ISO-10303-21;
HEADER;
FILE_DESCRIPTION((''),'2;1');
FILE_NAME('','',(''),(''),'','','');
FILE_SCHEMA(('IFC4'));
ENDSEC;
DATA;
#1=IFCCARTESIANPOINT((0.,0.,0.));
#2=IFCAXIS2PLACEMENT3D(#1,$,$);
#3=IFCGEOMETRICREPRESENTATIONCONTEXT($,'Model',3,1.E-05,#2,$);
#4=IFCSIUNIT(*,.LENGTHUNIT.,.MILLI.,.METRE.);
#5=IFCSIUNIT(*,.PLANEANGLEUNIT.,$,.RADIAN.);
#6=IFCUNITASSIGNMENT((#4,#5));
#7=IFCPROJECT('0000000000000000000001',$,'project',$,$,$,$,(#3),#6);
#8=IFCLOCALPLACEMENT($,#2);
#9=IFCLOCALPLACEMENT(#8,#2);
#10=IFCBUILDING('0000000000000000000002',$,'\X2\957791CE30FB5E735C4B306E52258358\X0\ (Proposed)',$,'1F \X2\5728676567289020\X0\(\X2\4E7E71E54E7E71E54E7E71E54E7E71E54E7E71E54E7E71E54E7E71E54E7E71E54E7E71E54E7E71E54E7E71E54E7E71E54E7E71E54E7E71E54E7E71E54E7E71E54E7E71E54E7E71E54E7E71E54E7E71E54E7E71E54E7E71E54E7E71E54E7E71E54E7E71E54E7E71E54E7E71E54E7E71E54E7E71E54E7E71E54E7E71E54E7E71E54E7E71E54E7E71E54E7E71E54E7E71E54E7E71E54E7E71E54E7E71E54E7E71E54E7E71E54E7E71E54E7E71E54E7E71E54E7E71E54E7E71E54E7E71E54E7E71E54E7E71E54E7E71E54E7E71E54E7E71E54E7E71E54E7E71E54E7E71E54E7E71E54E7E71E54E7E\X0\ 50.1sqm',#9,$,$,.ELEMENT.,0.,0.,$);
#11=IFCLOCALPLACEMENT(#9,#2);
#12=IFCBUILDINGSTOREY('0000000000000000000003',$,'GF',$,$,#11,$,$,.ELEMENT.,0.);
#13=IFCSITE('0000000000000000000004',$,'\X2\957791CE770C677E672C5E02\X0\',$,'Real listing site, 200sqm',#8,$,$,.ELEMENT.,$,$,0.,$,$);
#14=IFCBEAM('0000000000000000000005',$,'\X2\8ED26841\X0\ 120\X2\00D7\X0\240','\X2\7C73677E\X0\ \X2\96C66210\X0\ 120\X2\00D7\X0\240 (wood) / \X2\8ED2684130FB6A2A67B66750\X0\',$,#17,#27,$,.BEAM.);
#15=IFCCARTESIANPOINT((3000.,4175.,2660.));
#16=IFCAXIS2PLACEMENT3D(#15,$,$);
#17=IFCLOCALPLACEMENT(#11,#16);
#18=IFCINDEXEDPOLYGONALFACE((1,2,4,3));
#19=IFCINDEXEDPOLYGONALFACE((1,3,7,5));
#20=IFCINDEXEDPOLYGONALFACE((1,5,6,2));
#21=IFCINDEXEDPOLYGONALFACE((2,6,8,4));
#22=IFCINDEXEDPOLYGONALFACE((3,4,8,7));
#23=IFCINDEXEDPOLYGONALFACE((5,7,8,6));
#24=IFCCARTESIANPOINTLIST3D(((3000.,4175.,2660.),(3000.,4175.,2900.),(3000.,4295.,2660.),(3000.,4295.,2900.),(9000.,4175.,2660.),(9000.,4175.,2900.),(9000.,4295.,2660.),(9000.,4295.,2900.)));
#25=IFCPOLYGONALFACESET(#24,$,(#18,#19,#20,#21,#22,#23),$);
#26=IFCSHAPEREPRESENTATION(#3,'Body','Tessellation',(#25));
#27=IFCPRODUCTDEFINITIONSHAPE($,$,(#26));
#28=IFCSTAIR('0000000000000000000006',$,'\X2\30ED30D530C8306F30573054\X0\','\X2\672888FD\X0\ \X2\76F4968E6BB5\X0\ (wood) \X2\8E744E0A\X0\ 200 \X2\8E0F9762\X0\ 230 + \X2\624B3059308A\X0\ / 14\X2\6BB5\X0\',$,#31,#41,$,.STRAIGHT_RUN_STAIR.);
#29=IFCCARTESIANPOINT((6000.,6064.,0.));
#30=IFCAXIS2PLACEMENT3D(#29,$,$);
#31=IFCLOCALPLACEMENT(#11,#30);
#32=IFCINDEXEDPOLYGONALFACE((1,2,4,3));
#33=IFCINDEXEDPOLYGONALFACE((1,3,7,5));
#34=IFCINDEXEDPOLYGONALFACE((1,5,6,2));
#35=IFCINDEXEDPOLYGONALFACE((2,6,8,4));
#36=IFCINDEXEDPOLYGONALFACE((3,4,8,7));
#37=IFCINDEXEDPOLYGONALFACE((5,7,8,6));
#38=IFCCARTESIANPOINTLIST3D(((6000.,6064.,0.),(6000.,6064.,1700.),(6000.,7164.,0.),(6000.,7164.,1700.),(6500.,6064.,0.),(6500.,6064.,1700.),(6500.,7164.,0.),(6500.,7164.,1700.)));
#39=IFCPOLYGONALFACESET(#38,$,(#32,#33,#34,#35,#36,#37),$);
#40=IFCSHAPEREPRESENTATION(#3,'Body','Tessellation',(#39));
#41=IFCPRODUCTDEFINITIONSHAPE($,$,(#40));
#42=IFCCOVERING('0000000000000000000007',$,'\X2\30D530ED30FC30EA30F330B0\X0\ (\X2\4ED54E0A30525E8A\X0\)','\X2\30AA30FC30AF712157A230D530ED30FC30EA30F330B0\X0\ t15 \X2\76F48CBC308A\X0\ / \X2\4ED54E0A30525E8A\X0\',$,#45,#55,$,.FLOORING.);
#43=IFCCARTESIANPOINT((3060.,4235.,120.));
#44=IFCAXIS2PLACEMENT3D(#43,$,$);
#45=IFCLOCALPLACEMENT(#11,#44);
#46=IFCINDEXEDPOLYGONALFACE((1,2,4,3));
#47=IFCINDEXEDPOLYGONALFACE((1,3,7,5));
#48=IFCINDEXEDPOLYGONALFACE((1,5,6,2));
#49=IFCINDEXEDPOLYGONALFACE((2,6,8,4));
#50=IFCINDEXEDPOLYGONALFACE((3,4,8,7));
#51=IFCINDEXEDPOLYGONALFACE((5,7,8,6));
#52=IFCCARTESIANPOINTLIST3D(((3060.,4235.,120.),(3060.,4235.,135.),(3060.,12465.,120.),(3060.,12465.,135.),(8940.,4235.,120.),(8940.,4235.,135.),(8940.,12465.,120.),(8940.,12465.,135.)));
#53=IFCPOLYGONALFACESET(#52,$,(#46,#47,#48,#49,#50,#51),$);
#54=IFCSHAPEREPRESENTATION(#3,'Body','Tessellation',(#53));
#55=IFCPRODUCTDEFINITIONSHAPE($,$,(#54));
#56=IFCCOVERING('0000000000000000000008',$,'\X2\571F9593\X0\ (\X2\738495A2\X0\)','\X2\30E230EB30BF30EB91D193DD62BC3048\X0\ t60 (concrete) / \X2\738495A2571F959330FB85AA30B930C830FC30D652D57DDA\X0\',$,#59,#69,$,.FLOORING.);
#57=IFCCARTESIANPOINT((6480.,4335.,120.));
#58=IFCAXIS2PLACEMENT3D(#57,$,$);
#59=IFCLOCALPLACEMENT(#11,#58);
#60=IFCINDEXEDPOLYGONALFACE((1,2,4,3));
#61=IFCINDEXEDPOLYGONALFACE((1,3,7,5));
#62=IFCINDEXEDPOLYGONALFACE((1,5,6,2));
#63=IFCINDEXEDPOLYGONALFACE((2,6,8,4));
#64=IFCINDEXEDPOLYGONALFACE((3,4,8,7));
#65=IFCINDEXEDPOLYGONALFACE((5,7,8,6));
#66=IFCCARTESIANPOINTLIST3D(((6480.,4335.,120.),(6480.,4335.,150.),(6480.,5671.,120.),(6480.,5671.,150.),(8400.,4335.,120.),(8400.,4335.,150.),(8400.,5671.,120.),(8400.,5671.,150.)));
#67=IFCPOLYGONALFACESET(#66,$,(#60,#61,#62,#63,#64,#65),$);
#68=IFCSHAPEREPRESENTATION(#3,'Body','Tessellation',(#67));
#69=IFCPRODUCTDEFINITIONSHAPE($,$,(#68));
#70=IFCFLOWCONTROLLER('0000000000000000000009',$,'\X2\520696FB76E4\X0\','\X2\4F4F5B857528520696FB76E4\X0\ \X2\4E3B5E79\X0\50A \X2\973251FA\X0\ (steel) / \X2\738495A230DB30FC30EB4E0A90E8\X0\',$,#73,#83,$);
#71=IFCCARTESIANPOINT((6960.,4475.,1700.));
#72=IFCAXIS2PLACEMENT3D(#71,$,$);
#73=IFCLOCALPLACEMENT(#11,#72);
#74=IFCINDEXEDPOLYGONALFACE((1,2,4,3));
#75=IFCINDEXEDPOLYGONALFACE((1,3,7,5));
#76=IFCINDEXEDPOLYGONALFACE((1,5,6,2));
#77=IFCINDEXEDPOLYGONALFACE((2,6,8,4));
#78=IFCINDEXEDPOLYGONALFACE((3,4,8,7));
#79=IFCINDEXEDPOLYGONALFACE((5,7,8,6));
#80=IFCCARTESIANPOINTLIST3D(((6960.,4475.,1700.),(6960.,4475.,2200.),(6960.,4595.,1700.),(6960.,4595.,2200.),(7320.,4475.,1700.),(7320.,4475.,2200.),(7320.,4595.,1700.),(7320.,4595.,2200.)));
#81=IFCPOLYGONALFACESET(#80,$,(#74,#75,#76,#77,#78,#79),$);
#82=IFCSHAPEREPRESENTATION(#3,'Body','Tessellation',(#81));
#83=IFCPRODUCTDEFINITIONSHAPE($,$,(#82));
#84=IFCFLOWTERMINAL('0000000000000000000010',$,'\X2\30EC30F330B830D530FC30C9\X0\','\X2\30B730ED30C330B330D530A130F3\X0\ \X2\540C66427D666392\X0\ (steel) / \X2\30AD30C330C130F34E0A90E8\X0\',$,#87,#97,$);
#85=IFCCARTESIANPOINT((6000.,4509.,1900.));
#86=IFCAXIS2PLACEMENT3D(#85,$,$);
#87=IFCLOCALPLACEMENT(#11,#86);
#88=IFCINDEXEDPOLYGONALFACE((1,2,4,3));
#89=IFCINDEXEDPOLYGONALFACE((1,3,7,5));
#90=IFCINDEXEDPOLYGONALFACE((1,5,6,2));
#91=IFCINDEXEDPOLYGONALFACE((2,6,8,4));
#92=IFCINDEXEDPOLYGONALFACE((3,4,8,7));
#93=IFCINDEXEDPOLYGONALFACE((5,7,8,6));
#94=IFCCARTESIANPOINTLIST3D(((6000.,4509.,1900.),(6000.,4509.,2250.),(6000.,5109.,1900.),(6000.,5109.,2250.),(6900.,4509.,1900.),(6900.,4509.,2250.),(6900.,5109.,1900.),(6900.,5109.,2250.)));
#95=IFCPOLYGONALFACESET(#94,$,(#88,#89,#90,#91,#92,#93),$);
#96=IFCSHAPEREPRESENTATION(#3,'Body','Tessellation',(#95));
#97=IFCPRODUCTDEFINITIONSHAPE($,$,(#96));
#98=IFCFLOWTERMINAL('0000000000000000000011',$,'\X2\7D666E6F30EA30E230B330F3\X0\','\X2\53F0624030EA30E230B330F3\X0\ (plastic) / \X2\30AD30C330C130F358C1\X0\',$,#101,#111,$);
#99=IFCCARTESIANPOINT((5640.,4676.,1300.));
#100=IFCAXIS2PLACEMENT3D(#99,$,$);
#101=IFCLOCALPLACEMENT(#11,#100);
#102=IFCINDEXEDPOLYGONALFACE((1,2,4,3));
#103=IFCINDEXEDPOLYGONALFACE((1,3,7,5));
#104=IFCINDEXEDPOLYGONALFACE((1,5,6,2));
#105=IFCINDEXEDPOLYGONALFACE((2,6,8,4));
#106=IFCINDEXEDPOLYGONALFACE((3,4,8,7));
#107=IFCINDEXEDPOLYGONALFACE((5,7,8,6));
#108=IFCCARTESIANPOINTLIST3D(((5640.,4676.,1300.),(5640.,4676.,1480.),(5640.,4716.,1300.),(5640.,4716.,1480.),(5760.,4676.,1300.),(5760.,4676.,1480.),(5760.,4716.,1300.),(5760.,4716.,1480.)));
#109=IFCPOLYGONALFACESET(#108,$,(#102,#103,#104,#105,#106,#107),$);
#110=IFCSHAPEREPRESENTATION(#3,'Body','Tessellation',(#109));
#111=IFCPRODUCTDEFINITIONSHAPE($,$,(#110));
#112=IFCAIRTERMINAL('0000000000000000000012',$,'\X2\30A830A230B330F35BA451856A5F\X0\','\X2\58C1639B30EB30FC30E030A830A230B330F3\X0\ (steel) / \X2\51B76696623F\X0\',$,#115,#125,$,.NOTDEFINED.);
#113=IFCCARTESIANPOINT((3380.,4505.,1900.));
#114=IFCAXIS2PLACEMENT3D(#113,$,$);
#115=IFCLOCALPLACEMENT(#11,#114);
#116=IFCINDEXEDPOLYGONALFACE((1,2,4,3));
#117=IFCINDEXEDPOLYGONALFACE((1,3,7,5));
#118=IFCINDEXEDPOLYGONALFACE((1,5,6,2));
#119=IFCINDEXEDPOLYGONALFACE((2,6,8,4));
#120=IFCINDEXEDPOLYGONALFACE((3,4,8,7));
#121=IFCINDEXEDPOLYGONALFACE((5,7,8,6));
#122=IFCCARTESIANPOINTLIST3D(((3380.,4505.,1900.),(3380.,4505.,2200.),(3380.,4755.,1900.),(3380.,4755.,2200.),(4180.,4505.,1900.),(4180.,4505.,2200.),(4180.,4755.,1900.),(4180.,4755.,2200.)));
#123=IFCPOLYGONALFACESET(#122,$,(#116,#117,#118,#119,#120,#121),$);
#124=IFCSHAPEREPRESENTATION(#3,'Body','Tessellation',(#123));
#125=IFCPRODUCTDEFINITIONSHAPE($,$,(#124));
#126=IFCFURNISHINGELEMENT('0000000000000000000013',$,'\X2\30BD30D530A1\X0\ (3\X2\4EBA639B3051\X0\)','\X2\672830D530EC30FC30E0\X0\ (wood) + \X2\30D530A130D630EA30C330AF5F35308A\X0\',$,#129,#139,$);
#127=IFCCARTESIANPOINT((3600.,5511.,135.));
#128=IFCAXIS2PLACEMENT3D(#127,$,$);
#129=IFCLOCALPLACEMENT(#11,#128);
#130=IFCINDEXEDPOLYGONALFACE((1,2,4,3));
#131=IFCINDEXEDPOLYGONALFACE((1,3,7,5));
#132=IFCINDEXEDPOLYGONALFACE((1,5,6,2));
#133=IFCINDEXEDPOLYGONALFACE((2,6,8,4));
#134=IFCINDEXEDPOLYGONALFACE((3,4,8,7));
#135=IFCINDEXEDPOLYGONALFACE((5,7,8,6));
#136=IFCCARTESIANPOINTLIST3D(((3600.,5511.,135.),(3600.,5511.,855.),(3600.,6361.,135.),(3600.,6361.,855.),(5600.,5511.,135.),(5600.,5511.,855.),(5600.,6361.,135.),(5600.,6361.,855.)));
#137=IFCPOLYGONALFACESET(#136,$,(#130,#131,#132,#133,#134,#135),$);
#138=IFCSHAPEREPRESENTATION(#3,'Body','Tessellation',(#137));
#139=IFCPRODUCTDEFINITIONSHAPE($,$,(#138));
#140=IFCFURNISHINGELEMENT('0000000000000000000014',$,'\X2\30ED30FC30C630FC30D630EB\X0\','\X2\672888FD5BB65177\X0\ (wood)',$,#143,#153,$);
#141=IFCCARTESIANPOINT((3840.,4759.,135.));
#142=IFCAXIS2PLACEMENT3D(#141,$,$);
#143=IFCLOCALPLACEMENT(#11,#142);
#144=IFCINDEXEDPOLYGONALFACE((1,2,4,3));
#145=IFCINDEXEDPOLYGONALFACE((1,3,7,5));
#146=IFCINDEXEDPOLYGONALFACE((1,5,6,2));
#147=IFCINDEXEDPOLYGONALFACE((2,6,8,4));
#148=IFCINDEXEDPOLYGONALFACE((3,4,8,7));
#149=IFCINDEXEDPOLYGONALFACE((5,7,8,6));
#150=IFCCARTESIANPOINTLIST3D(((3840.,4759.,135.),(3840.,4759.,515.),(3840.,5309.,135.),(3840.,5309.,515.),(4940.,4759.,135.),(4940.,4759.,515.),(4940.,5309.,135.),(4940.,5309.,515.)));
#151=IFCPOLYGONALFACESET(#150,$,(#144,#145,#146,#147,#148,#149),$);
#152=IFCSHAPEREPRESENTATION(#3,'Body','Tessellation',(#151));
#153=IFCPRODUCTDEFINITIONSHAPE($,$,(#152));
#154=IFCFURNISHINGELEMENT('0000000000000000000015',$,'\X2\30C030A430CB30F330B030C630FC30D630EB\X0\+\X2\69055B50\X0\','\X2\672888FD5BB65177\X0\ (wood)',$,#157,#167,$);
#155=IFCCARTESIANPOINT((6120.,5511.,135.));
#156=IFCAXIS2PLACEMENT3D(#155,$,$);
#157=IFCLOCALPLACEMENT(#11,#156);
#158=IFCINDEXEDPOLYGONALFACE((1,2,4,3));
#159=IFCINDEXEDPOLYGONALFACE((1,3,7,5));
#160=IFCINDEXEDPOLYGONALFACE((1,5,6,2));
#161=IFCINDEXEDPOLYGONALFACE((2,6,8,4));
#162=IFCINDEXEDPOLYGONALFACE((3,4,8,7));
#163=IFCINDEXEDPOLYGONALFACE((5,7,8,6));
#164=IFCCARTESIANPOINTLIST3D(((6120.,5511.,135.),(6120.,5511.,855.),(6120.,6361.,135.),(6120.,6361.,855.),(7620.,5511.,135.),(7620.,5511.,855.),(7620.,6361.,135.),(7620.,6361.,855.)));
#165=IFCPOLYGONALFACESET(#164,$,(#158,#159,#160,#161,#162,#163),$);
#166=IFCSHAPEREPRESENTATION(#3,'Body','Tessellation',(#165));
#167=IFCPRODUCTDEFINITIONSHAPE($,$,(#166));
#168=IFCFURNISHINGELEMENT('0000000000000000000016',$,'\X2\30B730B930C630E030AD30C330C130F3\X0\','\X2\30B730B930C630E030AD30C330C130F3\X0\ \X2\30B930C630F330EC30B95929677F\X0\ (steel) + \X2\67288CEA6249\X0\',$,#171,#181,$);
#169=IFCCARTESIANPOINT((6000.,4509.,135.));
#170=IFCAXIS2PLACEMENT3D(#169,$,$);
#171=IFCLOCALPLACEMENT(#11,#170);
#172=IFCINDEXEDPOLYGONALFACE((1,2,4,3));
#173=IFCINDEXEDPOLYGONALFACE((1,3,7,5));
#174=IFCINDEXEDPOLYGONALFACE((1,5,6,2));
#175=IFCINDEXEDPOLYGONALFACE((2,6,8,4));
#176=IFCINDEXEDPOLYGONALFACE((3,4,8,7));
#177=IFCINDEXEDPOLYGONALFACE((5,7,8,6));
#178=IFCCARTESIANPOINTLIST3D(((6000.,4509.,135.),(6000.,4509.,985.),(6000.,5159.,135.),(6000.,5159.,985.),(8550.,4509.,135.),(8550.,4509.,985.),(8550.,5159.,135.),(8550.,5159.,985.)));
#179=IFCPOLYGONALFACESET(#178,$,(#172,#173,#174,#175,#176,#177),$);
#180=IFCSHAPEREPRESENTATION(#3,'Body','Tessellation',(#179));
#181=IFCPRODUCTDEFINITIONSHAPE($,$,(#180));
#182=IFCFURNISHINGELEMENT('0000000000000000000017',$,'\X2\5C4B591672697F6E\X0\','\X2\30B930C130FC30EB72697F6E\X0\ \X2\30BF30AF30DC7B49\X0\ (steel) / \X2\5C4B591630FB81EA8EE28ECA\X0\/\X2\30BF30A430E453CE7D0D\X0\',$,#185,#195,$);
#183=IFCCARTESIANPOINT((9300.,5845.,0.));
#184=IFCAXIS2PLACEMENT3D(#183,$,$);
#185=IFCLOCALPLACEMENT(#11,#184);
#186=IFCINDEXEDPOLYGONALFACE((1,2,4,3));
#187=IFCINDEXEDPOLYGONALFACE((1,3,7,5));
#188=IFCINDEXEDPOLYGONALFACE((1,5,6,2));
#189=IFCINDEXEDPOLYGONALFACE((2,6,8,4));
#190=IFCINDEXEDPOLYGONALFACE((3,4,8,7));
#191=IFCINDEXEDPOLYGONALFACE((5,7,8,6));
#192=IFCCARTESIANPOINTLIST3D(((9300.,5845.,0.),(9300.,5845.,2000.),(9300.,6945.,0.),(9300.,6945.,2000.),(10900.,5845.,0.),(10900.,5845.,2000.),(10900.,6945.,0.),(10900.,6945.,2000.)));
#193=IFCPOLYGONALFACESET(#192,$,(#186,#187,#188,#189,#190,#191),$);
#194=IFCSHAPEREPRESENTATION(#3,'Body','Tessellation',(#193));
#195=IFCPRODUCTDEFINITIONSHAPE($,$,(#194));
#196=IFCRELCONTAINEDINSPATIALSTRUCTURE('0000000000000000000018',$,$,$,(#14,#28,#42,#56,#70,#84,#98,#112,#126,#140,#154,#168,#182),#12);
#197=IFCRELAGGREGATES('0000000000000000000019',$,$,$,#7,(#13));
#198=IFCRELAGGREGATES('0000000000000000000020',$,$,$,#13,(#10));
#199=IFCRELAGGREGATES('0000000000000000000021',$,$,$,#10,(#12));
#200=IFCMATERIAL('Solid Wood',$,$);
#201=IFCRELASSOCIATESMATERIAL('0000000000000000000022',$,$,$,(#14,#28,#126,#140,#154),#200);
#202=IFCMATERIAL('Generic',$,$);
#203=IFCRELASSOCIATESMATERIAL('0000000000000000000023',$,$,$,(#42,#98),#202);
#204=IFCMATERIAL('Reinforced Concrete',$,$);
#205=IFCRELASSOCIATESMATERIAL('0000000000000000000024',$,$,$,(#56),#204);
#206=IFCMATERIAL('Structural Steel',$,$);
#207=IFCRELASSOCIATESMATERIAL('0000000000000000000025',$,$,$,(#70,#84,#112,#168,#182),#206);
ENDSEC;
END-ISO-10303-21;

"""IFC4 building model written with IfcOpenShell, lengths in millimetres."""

from ifc_helpers import new_model, si_unit, frame, frame_2d, origin, place, context, project, spatial, rectangle, extrude, material, element, save


model = new_model("IFC4")

# Units and contexts
model_context = context("Model", 3, precision=1e-05, world=origin())
ifc_project = project(units=[si_unit("LENGTHUNIT", "METRE", prefix="MILLI"), si_unit("PLANEANGLEUNIT", "RADIAN")], contexts=[model_context])

# Site, building, storey
site_placement = place(None, origin())
site = spatial("IfcSite", under=ifc_project, at=site_placement, Name="長野県松本市", ObjectType="Real listing site, 200sqm", CompositionType="ELEMENT", RefElevation=0.0)
building_placement = place(site_placement, origin())
building = spatial("IfcBuilding", under=site, at=building_placement, Name="長野・平屋の別荘 (Proposed)", ObjectType="1F 在来木造(乾燥乾燥乾燥乾燥乾燥乾燥乾燥乾燥乾燥乾燥乾燥乾燥乾燥乾燥乾燥乾燥乾燥乾燥乾燥乾燥乾燥乾燥乾燥乾燥乾燥乾燥乾燥乾燥乾燥乾燥乾燥乾燥乾燥乾燥乾燥乾燥乾燥乾燥乾燥乾燥乾燥乾燥乾燥乾燥乾燥乾燥乾燥乾燥乾燥乾燥乾燥乾燥乾燥乾燥乾燥乾燥乾燥乾 50.1sqm", CompositionType="ELEMENT", ElevationOfRefHeight=0.0, ElevationOfTerrain=0.0)
storey_placement = place(building_placement, origin())
storey = spatial("IfcBuildingStorey", under=building, at=storey_placement, Name="GF", CompositionType="ELEMENT", Elevation=0.0)

# Beam
ifc_material_1 = material(Name="Solid Wood")
beam_1_placement = place(storey_placement, frame((3000.0, 4175.0, 2660.0)))
element("IfcBeam", 1, at=beam_1_placement, inside=storey, material=ifc_material_1, Name="軒桁 120×240", Description="米松 集成 120×240 (wood) / 軒桁・横架材", PredefinedType="BEAM", context=model_context, shape_type="SweptSolid", body=[
    extrude(rectangle(XDim=6000.0, YDim=120.0, at=frame_2d((3000.0, 60.0))), frame((3000.0, 4175.0, 2660.0)), (0.0, 0.0, 1.0), 240.0),
])

# Stair
stair_placement = place(storey_placement, frame((6000.0, 6064.0, 0.0)))
element("IfcStair", 2, at=stair_placement, inside=storey, material=ifc_material_1, Name="ロフトはしご", Description="木製 直階段 (wood) 蹴上 200 踏面 230 + 手すり / 14段", PredefinedType="STRAIGHT_RUN_STAIR", context=model_context, shape_type="SweptSolid", body=[
    extrude(rectangle(XDim=500.0, YDim=1100.0, at=frame_2d((250.0, 550.0))), frame((6000.0, 6064.0, 0.0)), (0.0, 0.0, 1.0), 1700.0),
])

# Coverings
ifc_material_2 = material(Name="Generic")
covering_1_placement = place(storey_placement, frame((3060.0, 4235.0, 120.0)))
element("IfcCovering", 3, at=covering_1_placement, inside=storey, material=ifc_material_2, Name="フローリング (仕上げ床)", Description="オーク無垢フローリング t15 直貼り / 仕上げ床", PredefinedType="FLOORING", context=model_context, shape_type="SweptSolid", body=[
    extrude(rectangle(XDim=5880.0, YDim=8230.0, at=frame_2d((2940.0, 4115.0))), frame((3060.0, 4235.0, 120.0)), (0.0, 0.0, 1.0), 15.0),
])
ifc_material_3 = material(Name="Reinforced Concrete")
covering_2_placement = place(storey_placement, frame((6480.0, 4335.0, 120.0)))
element("IfcCovering", 4, at=covering_2_placement, inside=storey, material=ifc_material_3, Name="土間 (玄関)", Description="モルタル金鏝押え t60 (concrete) / 玄関土間・薪ストーブ動線", PredefinedType="FLOORING", context=model_context, shape_type="SweptSolid", body=[
    extrude(rectangle(XDim=1920.0, YDim=1336.0, at=frame_2d((960.0, 668.0))), frame((6480.0, 4335.0, 120.0)), (0.0, 0.0, 1.0), 30.0),
])

# Flow controller
ifc_material_4 = material(Name="Structural Steel")
flow_controller_placement = place(storey_placement, frame((6960.0, 4475.0, 1700.0)))
element("IfcFlowController", 5, at=flow_controller_placement, inside=storey, material=ifc_material_4, Name="分電盤", Description="住宅用分電盤 主幹50A 露出 (steel) / 玄関ホール上部", context=model_context, shape_type="SweptSolid", body=[
    extrude(rectangle(XDim=360.0, YDim=120.0, at=frame_2d((180.0, 60.0))), frame((6960.0, 4475.0, 1700.0)), (0.0, 0.0, 1.0), 500.0),
])

# Flow terminals
flow_terminal_1_placement = place(storey_placement, frame((6000.0, 4509.0, 1900.0)))
element("IfcFlowTerminal", 6, at=flow_terminal_1_placement, inside=storey, material=ifc_material_4, Name="レンジフード", Description="シロッコファン 同時給排 (steel) / キッチン上部", context=model_context, shape_type="SweptSolid", body=[
    extrude(rectangle(XDim=900.0, YDim=600.0, at=frame_2d((450.0, 300.0))), frame((6000.0, 4509.0, 1900.0)), (0.0, 0.0, 1.0), 350.0),
])
flow_terminal_2_placement = place(storey_placement, frame((5640.0, 4676.0, 1300.0)))
element("IfcFlowTerminal", 7, at=flow_terminal_2_placement, inside=storey, material=ifc_material_2, Name="給湯リモコン", Description="台所リモコン (plastic) / キッチン壁", context=model_context, shape_type="SweptSolid", body=[
    extrude(rectangle(XDim=120.0, YDim=40.0, at=frame_2d((60.0, 20.0))), frame((5640.0, 4676.0, 1300.0)), (0.0, 0.0, 1.0), 180.0),
])

# Air terminal
air_terminal_placement = place(storey_placement, frame((3380.0, 4505.0, 1900.0)))
element("IfcAirTerminal", 8, at=air_terminal_placement, inside=storey, material=ifc_material_4, Name="エアコン室内機", Description="壁掛ルームエアコン (steel) / 冷暖房", PredefinedType="NOTDEFINED", context=model_context, shape_type="SweptSolid", body=[
    extrude(rectangle(XDim=800.0, YDim=250.0, at=frame_2d((400.0, 125.0))), frame((3380.0, 4505.0, 1900.0)), (0.0, 0.0, 1.0), 300.0),
])

# Furnishing elements
furnishing_1_placement = place(storey_placement, frame((3600.0, 5511.0, 135.0)))
element("IfcFurnishingElement", 9, at=furnishing_1_placement, inside=storey, material=ifc_material_1, Name="ソファ (3人掛け)", Description="木フレーム (wood) + ファブリック張り", context=model_context, shape_type="SweptSolid", body=[
    extrude(rectangle(XDim=2000.0, YDim=850.0, at=frame_2d((1000.0, 425.0))), frame((3600.0, 5511.0, 135.0)), (0.0, 0.0, 1.0), 720.0),
])
furnishing_2_placement = place(storey_placement, frame((3840.0, 4759.0, 135.0)))
element("IfcFurnishingElement", 10, at=furnishing_2_placement, inside=storey, material=ifc_material_1, Name="ローテーブル", Description="木製家具 (wood)", context=model_context, shape_type="SweptSolid", body=[
    extrude(rectangle(XDim=1100.0, YDim=550.0, at=frame_2d((550.0, 275.0))), frame((3840.0, 4759.0, 135.0)), (0.0, 0.0, 1.0), 380.0),
])
furnishing_3_placement = place(storey_placement, frame((6120.0, 5511.0, 135.0)))
element("IfcFurnishingElement", 11, at=furnishing_3_placement, inside=storey, material=ifc_material_1, Name="ダイニングテーブル+椅子", Description="木製家具 (wood)", context=model_context, shape_type="SweptSolid", body=[
    extrude(rectangle(XDim=1500.0, YDim=850.0, at=frame_2d((750.0, 425.0))), frame((6120.0, 5511.0, 135.0)), (0.0, 0.0, 1.0), 720.0),
])
furnishing_4_placement = place(storey_placement, frame((6000.0, 4509.0, 135.0)))
element("IfcFurnishingElement", 12, at=furnishing_4_placement, inside=storey, material=ifc_material_4, Name="システムキッチン", Description="システムキッチン ステンレス天板 (steel) + 木質扉", context=model_context, shape_type="SweptSolid", body=[
    extrude(rectangle(XDim=2550.0, YDim=650.0, at=frame_2d((1275.0, 325.0))), frame((6000.0, 4509.0, 135.0)), (0.0, 0.0, 1.0), 850.0),
])
furnishing_5_placement = place(storey_placement, frame((9300.0, 5845.0, 0.0)))
element("IfcFurnishingElement", 13, at=furnishing_5_placement, inside=storey, material=ifc_material_4, Name="屋外物置", Description="スチール物置 タクボ等 (steel) / 屋外・自転車/タイヤ収納", context=model_context, shape_type="SweptSolid", body=[
    extrude(rectangle(XDim=1600.0, YDim=1100.0, at=frame_2d((800.0, 550.0))), frame((9300.0, 5845.0, 0.0)), (0.0, 0.0, 1.0), 2000.0),
])

save(model, "model.ifc")
